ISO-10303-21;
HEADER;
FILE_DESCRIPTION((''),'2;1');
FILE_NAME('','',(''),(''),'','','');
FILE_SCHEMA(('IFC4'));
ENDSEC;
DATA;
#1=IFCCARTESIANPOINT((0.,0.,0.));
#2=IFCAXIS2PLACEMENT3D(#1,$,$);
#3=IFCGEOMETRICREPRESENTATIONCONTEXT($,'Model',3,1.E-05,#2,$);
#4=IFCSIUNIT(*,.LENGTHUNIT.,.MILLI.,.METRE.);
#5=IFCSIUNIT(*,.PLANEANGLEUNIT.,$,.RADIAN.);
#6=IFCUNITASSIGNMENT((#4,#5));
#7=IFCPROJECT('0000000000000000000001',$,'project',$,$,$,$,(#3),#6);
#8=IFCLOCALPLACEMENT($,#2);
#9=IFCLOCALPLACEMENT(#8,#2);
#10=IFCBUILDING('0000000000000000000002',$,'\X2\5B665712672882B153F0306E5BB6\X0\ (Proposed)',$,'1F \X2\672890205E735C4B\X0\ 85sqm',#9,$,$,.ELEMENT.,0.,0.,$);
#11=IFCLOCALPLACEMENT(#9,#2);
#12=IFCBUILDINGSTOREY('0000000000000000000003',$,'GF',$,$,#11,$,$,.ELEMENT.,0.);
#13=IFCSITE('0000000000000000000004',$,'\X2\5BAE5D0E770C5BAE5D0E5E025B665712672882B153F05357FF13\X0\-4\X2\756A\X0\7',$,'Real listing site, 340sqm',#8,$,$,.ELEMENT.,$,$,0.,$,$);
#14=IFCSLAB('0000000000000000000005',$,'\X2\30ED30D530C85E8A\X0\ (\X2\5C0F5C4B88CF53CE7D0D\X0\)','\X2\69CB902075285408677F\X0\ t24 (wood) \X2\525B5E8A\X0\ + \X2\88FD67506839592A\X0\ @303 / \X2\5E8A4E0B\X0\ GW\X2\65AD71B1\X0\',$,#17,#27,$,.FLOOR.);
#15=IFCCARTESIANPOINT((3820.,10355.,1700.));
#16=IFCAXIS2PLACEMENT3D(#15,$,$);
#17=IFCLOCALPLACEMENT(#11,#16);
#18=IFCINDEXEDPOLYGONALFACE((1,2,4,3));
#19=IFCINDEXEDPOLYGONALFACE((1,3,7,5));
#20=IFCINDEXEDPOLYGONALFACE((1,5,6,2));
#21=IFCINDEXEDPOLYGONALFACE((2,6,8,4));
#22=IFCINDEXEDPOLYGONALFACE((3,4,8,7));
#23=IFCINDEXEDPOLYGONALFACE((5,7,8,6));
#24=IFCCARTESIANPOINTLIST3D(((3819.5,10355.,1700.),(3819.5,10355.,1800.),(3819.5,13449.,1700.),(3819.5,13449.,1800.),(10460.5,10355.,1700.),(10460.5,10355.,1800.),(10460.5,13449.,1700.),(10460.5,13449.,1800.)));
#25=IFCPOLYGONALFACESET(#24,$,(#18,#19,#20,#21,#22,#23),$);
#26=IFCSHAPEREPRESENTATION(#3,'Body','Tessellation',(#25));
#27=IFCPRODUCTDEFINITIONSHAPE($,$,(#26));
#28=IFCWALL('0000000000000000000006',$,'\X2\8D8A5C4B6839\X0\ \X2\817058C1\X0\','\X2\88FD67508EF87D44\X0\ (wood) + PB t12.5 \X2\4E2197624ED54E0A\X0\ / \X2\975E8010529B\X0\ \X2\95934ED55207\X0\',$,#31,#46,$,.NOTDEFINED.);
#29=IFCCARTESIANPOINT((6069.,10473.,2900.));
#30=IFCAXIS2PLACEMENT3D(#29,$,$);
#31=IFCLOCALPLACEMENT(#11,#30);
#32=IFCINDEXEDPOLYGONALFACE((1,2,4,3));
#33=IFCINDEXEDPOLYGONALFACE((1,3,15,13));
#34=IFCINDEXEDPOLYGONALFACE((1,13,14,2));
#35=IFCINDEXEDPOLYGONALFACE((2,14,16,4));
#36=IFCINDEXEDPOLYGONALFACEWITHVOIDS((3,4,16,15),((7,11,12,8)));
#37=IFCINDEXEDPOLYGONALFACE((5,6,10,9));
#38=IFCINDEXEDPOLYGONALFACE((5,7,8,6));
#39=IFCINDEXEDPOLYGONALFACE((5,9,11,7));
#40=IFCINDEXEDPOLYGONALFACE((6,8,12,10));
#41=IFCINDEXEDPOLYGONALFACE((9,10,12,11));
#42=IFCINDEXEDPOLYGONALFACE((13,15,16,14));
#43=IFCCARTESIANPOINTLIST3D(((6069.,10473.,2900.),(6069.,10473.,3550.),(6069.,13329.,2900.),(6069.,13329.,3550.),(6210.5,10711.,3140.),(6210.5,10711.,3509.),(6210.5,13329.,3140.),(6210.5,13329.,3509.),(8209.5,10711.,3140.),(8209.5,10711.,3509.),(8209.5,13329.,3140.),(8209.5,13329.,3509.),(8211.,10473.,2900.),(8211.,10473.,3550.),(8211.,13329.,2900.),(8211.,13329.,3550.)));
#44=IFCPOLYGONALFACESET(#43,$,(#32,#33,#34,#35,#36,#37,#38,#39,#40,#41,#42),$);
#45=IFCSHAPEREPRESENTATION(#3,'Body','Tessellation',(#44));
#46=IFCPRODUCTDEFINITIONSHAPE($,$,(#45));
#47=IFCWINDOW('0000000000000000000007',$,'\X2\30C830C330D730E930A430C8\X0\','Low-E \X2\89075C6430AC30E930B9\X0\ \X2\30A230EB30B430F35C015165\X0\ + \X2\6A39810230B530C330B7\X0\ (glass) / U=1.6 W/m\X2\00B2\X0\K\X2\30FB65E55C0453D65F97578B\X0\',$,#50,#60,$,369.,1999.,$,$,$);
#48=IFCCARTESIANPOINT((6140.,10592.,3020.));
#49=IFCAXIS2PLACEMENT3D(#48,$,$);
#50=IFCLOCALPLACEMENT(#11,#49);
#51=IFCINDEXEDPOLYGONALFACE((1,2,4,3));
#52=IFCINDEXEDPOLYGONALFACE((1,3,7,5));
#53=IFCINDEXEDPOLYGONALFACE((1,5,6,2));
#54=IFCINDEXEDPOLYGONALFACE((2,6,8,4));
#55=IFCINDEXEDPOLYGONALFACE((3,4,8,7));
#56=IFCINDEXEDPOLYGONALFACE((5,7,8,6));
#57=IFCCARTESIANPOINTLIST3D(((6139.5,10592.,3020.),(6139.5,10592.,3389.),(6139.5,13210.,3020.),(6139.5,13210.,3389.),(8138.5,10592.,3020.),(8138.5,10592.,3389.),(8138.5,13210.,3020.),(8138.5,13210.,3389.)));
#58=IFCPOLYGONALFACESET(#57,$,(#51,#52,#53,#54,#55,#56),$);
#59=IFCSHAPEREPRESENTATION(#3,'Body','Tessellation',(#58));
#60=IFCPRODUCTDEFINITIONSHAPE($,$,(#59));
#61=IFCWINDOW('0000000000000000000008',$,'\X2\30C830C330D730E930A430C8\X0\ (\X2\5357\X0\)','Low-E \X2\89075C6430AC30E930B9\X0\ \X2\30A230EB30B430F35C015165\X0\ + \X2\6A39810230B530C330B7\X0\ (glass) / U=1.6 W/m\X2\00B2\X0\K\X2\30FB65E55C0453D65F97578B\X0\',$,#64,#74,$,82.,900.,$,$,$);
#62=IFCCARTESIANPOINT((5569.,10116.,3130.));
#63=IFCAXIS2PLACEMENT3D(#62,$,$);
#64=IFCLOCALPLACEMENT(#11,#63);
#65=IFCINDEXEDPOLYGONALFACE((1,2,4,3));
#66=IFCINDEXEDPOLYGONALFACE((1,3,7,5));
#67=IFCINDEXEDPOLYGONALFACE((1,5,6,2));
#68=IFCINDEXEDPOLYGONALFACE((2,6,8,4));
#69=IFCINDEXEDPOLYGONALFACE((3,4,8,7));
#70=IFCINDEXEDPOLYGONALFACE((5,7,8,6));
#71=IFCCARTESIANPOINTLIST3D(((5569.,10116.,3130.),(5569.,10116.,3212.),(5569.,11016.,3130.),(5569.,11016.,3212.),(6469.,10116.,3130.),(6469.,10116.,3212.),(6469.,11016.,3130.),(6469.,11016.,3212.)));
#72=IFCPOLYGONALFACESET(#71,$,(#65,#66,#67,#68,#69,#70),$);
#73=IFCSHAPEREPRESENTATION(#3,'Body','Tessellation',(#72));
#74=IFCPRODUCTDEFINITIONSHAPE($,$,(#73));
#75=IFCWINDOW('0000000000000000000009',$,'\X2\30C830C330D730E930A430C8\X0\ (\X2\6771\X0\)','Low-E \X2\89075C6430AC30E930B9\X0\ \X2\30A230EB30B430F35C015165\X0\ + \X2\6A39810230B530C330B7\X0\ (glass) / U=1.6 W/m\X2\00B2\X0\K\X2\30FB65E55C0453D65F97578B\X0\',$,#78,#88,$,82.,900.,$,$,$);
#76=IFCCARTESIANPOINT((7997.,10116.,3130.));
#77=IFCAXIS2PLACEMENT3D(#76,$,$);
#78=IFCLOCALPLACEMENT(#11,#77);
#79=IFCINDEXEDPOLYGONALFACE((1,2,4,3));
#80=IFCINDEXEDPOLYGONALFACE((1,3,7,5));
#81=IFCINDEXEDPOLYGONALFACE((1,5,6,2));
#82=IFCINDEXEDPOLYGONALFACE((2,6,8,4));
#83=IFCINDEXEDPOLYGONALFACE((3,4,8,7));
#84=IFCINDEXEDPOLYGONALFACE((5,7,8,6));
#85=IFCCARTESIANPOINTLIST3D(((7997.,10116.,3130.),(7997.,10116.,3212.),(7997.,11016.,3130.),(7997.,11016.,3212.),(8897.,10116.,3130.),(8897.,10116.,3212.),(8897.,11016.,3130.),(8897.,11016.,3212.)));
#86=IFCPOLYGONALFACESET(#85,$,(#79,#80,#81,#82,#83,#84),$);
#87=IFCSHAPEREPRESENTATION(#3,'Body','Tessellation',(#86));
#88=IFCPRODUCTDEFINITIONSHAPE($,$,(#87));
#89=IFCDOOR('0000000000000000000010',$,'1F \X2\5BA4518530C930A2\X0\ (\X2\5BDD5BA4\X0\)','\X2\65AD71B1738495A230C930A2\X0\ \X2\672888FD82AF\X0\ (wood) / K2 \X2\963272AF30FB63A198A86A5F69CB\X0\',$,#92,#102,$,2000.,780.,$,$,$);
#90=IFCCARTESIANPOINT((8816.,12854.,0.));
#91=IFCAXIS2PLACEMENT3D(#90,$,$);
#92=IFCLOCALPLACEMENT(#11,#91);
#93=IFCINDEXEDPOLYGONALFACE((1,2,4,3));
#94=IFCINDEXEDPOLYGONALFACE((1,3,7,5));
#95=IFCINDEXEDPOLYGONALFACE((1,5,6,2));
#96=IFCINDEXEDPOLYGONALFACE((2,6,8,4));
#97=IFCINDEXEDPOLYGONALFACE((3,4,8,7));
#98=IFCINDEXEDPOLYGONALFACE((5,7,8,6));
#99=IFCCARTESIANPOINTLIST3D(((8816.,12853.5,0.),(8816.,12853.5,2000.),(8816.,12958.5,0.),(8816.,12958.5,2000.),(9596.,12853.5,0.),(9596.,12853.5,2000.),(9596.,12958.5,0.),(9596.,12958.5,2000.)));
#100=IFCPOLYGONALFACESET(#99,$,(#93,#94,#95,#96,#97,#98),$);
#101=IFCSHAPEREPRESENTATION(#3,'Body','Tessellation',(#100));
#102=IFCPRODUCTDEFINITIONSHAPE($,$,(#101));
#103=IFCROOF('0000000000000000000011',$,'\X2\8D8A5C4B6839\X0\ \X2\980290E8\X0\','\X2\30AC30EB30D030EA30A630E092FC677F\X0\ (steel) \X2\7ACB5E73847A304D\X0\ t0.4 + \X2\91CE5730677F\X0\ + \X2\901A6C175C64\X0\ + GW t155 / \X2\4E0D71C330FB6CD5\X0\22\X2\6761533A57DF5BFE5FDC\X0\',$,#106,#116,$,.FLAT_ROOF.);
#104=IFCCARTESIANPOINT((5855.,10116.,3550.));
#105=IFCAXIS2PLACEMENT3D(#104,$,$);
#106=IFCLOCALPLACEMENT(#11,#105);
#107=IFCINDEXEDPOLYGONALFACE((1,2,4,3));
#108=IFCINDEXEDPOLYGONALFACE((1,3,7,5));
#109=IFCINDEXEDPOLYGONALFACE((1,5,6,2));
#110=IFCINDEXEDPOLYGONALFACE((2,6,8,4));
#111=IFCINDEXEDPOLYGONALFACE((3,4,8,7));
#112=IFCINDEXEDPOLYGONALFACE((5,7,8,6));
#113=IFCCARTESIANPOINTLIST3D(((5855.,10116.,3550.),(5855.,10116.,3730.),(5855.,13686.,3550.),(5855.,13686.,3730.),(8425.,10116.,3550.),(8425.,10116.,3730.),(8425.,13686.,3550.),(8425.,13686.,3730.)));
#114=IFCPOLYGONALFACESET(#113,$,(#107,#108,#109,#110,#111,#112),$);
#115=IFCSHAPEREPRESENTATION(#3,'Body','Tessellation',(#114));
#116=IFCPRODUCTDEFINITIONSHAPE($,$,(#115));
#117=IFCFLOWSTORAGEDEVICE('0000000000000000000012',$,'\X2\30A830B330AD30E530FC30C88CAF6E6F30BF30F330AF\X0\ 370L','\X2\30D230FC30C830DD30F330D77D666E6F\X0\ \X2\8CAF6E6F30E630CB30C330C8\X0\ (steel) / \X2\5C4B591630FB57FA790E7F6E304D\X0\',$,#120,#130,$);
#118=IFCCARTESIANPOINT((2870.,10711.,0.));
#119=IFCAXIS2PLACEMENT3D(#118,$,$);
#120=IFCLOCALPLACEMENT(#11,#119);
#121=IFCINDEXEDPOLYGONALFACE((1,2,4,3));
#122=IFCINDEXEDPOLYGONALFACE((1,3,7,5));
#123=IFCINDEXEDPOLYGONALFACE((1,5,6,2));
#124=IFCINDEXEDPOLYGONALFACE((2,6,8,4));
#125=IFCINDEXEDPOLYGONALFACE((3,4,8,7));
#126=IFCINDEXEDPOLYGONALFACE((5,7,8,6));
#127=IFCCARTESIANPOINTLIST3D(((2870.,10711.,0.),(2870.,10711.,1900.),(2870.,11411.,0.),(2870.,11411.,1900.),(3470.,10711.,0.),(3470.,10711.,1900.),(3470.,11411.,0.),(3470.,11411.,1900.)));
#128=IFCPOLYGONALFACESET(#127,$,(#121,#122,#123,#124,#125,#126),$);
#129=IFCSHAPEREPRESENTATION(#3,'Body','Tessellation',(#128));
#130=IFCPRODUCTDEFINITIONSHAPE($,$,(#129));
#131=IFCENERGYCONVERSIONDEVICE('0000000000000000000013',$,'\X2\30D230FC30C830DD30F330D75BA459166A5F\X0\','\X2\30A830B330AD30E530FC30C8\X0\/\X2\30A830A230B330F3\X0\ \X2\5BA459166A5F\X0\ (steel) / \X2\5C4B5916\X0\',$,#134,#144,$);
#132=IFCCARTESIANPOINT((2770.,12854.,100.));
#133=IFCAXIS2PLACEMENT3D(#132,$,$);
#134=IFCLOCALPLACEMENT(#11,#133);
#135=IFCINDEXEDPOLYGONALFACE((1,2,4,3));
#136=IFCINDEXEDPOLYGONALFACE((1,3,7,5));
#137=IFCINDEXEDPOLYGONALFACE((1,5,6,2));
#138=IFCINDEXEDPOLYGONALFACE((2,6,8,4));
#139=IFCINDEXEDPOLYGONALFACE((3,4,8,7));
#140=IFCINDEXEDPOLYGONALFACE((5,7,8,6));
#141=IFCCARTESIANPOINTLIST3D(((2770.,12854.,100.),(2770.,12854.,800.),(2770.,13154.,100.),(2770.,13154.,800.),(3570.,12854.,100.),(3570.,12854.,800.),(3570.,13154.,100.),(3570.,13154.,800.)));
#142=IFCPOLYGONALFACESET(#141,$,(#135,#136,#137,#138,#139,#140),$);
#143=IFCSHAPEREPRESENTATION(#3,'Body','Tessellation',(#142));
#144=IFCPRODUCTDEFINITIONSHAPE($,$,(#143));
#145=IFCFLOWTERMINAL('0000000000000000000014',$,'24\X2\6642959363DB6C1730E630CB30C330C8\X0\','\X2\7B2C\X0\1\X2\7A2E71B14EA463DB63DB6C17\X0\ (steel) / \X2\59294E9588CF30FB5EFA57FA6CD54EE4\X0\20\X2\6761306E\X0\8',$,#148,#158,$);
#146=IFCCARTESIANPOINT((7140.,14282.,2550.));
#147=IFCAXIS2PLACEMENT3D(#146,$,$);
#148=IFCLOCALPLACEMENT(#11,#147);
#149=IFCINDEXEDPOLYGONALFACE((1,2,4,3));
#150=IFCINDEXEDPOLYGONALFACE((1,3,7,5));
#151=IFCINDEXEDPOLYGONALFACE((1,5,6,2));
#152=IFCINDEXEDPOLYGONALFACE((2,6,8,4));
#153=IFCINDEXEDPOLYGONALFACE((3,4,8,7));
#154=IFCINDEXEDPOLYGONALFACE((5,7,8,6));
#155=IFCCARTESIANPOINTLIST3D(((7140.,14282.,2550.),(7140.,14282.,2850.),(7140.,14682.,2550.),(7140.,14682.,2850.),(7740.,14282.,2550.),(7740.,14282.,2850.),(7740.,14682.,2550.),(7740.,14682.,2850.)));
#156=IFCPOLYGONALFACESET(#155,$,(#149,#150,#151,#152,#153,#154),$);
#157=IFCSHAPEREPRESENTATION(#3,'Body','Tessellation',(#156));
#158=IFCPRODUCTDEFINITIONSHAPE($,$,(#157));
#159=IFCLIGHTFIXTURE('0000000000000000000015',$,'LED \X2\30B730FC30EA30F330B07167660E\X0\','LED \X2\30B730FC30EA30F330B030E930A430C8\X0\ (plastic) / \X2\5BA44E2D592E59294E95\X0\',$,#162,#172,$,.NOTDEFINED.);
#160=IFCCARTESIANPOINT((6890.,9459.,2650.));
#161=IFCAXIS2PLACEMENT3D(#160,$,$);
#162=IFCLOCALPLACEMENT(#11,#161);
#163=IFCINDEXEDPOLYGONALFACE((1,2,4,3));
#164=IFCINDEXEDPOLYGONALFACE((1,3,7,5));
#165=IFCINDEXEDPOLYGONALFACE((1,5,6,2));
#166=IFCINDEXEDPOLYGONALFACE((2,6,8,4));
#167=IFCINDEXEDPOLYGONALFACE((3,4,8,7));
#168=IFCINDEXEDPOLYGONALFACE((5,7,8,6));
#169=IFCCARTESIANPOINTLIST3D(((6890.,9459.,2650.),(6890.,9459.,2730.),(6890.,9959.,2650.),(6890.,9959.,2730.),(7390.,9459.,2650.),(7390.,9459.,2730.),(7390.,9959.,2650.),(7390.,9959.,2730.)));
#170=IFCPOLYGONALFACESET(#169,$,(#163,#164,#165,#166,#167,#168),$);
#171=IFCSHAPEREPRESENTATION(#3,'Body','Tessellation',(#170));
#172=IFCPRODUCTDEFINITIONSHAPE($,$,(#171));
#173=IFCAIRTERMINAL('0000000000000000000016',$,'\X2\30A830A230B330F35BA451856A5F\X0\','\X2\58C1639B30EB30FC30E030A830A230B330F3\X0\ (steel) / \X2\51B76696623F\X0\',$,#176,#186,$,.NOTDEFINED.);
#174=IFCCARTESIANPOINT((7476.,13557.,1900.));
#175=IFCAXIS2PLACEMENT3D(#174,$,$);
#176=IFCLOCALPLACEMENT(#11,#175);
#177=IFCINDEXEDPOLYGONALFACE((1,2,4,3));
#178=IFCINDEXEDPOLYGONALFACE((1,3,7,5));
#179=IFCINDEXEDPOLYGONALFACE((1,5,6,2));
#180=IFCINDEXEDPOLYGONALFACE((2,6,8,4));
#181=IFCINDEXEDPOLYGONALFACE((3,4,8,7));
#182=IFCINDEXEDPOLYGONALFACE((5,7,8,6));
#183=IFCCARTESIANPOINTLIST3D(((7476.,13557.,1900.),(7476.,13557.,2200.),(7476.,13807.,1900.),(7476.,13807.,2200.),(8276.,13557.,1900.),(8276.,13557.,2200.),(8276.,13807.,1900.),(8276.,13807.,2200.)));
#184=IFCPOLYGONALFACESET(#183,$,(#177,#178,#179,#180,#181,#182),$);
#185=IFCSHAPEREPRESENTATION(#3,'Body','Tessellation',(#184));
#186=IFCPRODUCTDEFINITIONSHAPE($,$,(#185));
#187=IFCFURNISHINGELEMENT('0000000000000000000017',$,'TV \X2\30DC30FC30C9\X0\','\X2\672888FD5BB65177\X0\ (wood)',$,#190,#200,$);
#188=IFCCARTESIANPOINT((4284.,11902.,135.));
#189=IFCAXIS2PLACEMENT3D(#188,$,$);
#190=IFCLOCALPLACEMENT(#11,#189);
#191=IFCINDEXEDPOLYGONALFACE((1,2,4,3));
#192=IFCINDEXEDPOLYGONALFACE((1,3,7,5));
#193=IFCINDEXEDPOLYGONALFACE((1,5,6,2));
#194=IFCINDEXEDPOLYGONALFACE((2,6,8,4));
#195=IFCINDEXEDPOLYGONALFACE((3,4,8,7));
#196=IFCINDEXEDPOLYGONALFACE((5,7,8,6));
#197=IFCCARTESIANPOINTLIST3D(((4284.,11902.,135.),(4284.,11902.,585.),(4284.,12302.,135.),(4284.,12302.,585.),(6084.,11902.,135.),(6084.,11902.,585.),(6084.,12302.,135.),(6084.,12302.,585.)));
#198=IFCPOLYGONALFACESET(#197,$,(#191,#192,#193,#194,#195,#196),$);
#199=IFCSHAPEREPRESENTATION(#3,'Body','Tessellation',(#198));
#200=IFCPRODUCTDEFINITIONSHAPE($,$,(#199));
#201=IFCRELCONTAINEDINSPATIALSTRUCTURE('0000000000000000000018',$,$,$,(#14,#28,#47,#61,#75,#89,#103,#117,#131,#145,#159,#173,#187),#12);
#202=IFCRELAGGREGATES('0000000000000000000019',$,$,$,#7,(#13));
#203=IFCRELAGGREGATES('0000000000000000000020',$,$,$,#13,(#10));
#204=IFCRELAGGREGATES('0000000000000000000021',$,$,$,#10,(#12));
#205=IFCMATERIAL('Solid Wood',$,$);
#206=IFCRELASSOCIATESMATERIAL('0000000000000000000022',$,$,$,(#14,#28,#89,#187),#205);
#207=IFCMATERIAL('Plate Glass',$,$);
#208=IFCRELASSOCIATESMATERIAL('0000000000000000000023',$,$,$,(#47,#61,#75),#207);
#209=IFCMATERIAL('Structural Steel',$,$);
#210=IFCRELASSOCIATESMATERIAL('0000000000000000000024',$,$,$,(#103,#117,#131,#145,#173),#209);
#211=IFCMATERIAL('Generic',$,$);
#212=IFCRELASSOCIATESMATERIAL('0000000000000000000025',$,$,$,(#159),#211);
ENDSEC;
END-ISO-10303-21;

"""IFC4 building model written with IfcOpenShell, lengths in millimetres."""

from ifc_helpers import new_model, si_unit, frame, frame_2d, origin, place, context, project, spatial, rectangle, extrude, material, element, fill, save


model = new_model("IFC4")

# Units and contexts
model_context = context("Model", 3, precision=1e-05, world=origin())
ifc_project = project(units=[si_unit("LENGTHUNIT", "METRE", prefix="MILLI"), si_unit("PLANEANGLEUNIT", "RADIAN")], contexts=[model_context])

# Site, building, storey
site_placement = place(None, origin())
site = spatial("IfcSite", under=ifc_project, at=site_placement, Name="宮崎県宮崎市学園木花台南３-4番7", ObjectType="Real listing site, 340sqm", CompositionType="ELEMENT", RefElevation=0.0)
building_placement = place(site_placement, origin())
building = spatial("IfcBuilding", under=site, at=building_placement, Name="学園木花台の家 (Proposed)", ObjectType="1F 木造平屋 85sqm", CompositionType="ELEMENT", ElevationOfRefHeight=0.0, ElevationOfTerrain=0.0)
storey_placement = place(building_placement, origin())
storey = spatial("IfcBuildingStorey", under=building, at=storey_placement, Name="GF", CompositionType="ELEMENT", Elevation=0.0)

# Shared definitions
ifc_material_1 = material(Name="Solid Wood")

# Slab
slab_placement = place(storey_placement, frame((3820.0, 10355.0, 1700.0)))
element("IfcSlab", 1, at=slab_placement, inside=storey, material=ifc_material_1, Name="ロフト床 (小屋裏収納)", Description="構造用合板 t24 (wood) 剛床 + 製材根太 @303 / 床下 GW断熱", PredefinedType="FLOOR", context=model_context, shape_type="SweptSolid", body=[
    extrude(rectangle(XDim=6641.0, YDim=3094.0, at=frame_2d((3320.0, 1547.0))), frame((3820.0, 10355.0, 1700.0)), (0.0, 0.0, 1.0), 100.0),
])

# Wall, openings, windows
wall_1_placement = place(storey_placement, frame((6069.0, 10473.0, 2900.0)))
wall_1 = element("IfcWall", 2, at=wall_1_placement, inside=storey, material=ifc_material_1, Name="越屋根 腰壁", Description="製材軸組 (wood) + PB t12.5 両面仕上 / 非耐力 間仕切", PredefinedType="NOTDEFINED", context=model_context, shape_type="SweptSolid", body=[
    extrude(rectangle(XDim=2142.0, YDim=2856.0, at=frame_2d((1071.0, 1428.0))), frame((6069.0, 10473.0, 2900.0)), (0.0, 0.0, 1.0), 650.0),
])
opening_1_placement = place(storey_placement, frame((6140.0, 10592.0, 3020.0)))
opening_1 = element("IfcOpeningElement", 3, at=opening_1_placement, cuts=wall_1, PredefinedType="NOTDEFINED", context=model_context, shape_type="SweptSolid", body=[
    extrude(rectangle(XDim=1999.0, YDim=2618.0, at=frame_2d((999.0, 1309.0))), frame((6140.0, 10592.0, 3020.0)), (0.0, 0.0, 1.0), 369.0),
])
opening_2_placement = place(storey_placement, frame((5569.0, 10116.0, 3130.0)))
opening_2 = element("IfcOpeningElement", 4, at=opening_2_placement, cuts=wall_1, PredefinedType="NOTDEFINED", context=model_context, shape_type="SweptSolid", body=[
    extrude(rectangle(XDim=900.0, YDim=900.0, at=frame_2d((450.0, 450.0))), frame((5569.0, 10116.0, 3130.0)), (0.0, 0.0, 1.0), 82.0),
])
opening_3_placement = place(storey_placement, frame((7997.0, 10116.0, 3130.0)))
opening_3 = element("IfcOpeningElement", 5, at=opening_3_placement, cuts=wall_1, PredefinedType="NOTDEFINED", context=model_context, shape_type="SweptSolid", body=[
    extrude(rectangle(XDim=900.0, YDim=900.0, at=frame_2d((450.0, 450.0))), frame((7997.0, 10116.0, 3130.0)), (0.0, 0.0, 1.0), 82.0),
])
ifc_material_2 = material(Name="Plate Glass")
window_1_placement = place(storey_placement, frame((6140.0, 10592.0, 3020.0)))
window_1 = element("IfcWindow", 6, at=window_1_placement, inside=storey, material=ifc_material_2, Name="トップライト", Description="Low-E 複層ガラス アルゴン封入 + 樹脂サッシ (glass) / U=1.6 W/m²K・日射取得型", OverallHeight=369.0, OverallWidth=1999.0, context=model_context, shape_type="SweptSolid", body=[
    extrude(rectangle(XDim=1999.0, YDim=2618.0, at=frame_2d((999.0, 1309.0))), frame((6140.0, 10592.0, 3020.0)), (0.0, 0.0, 1.0), 369.0),
])
fill(opening_1, window_1)
window_2_placement = place(storey_placement, frame((5569.0, 10116.0, 3130.0)))
window_2 = element("IfcWindow", 7, at=window_2_placement, inside=storey, material=ifc_material_2, Name="トップライト (南)", Description="Low-E 複層ガラス アルゴン封入 + 樹脂サッシ (glass) / U=1.6 W/m²K・日射取得型", OverallHeight=82.0, OverallWidth=900.0, context=model_context, shape_type="SweptSolid", body=[
    extrude(rectangle(XDim=900.0, YDim=900.0, at=frame_2d((450.0, 450.0))), frame((5569.0, 10116.0, 3130.0)), (0.0, 0.0, 1.0), 82.0),
])
fill(opening_2, window_2)
window_3_placement = place(storey_placement, frame((7997.0, 10116.0, 3130.0)))
window_3 = element("IfcWindow", 8, at=window_3_placement, inside=storey, material=ifc_material_2, Name="トップライト (東)", Description="Low-E 複層ガラス アルゴン封入 + 樹脂サッシ (glass) / U=1.6 W/m²K・日射取得型", OverallHeight=82.0, OverallWidth=900.0, context=model_context, shape_type="SweptSolid", body=[
    extrude(rectangle(XDim=900.0, YDim=900.0, at=frame_2d((450.0, 450.0))), frame((7997.0, 10116.0, 3130.0)), (0.0, 0.0, 1.0), 82.0),
])
fill(opening_3, window_3)

# Door
door_1_placement = place(storey_placement, frame((8816.0, 12854.0, 0.0)))
element("IfcDoor", 9, at=door_1_placement, inside=storey, material=ifc_material_1, Name="1F 室内ドア (寝室)", Description="断熱玄関ドア 木製芯 (wood) / K2 防犯・採風機構", OverallHeight=2000.0, OverallWidth=780.0, context=model_context, shape_type="SweptSolid", body=[
    extrude(rectangle(XDim=780.0, YDim=105.0, at=frame_2d((390.0, 52.0))), frame((8816.0, 12854.0, 0.0)), (0.0, 0.0, 1.0), 2000.0),
])

# Roof
ifc_material_3 = material(Name="Structural Steel")
roof_placement = place(storey_placement, frame((5855.0, 10116.0, 3550.0)))
element("IfcRoof", 10, at=roof_placement, inside=storey, material=ifc_material_3, Name="越屋根 頂部", Description="ガルバリウム鋼板 (steel) 立平葺き t0.4 + 野地板 + 通気層 + GW t155 / 不燃・法22条区域対応", PredefinedType="FLAT_ROOF", context=model_context, shape_type="SweptSolid", body=[
    extrude(rectangle(XDim=2570.0, YDim=3570.0, at=frame_2d((1285.0, 1785.0))), frame((5855.0, 10116.0, 3550.0)), (0.0, 0.0, 1.0), 180.0),
])

# Flow storage device
flow_storage_device_placement = place(storey_placement, frame((2870.0, 10711.0, 0.0)))
element("IfcFlowStorageDevice", 11, at=flow_storage_device_placement, inside=storey, material=ifc_material_3, Name="エコキュート貯湯タンク 370L", Description="ヒートポンプ給湯 貯湯ユニット (steel) / 屋外・基礎置き", context=model_context, shape_type="SweptSolid", body=[
    extrude(rectangle(XDim=600.0, YDim=700.0, at=frame_2d((300.0, 350.0))), frame((2870.0, 10711.0, 0.0)), (0.0, 0.0, 1.0), 1900.0),
])

# Energy conversion device
energy_conversion_device_placement = place(storey_placement, frame((2770.0, 12854.0, 100.0)))
element("IfcEnergyConversionDevice", 12, at=energy_conversion_device_placement, inside=storey, material=ifc_material_3, Name="ヒートポンプ室外機", Description="エコキュート/エアコン 室外機 (steel) / 屋外", context=model_context, shape_type="SweptSolid", body=[
    extrude(rectangle(XDim=800.0, YDim=300.0, at=frame_2d((400.0, 150.0))), frame((2770.0, 12854.0, 100.0)), (0.0, 0.0, 1.0), 700.0),
])

# Flow terminal
flow_terminal_placement = place(storey_placement, frame((7140.0, 14282.0, 2550.0)))
element("IfcFlowTerminal", 13, at=flow_terminal_placement, inside=storey, material=ifc_material_3, Name="24時間換気ユニット", Description="第1種熱交換換気 (steel) / 天井裏・建基法令20条の8", context=model_context, shape_type="SweptSolid", body=[
    extrude(rectangle(XDim=600.0, YDim=400.0, at=frame_2d((300.0, 200.0))), frame((7140.0, 14282.0, 2550.0)), (0.0, 0.0, 1.0), 300.0),
])

# Light fixture
ifc_material_4 = material(Name="Generic")
light_fixture_placement = place(storey_placement, frame((6890.0, 9459.0, 2650.0)))
element("IfcLightFixture", 14, at=light_fixture_placement, inside=storey, material=ifc_material_4, Name="LED シーリング照明", Description="LED シーリングライト (plastic) / 室中央天井", PredefinedType="NOTDEFINED", context=model_context, shape_type="SweptSolid", body=[
    extrude(rectangle(XDim=500.0, YDim=500.0, at=frame_2d((250.0, 250.0))), frame((6890.0, 9459.0, 2650.0)), (0.0, 0.0, 1.0), 80.0),
])

# Air terminal
air_terminal_placement = place(storey_placement, frame((7476.0, 13557.0, 1900.0)))
element("IfcAirTerminal", 15, at=air_terminal_placement, inside=storey, material=ifc_material_3, Name="エアコン室内機", Description="壁掛ルームエアコン (steel) / 冷暖房", PredefinedType="NOTDEFINED", context=model_context, shape_type="SweptSolid", body=[
    extrude(rectangle(XDim=800.0, YDim=250.0, at=frame_2d((400.0, 125.0))), frame((7476.0, 13557.0, 1900.0)), (0.0, 0.0, 1.0), 300.0),
])

# Furnishing element
furnishing_placement = place(storey_placement, frame((4284.0, 11902.0, 135.0)))
element("IfcFurnishingElement", 16, at=furnishing_placement, inside=storey, material=ifc_material_1, Name="TV ボード", Description="木製家具 (wood)", context=model_context, shape_type="SweptSolid", body=[
    extrude(rectangle(XDim=1800.0, YDim=400.0, at=frame_2d((900.0, 200.0))), frame((4284.0, 11902.0, 135.0)), (0.0, 0.0, 1.0), 450.0),
])

save(model, "model.ifc")
